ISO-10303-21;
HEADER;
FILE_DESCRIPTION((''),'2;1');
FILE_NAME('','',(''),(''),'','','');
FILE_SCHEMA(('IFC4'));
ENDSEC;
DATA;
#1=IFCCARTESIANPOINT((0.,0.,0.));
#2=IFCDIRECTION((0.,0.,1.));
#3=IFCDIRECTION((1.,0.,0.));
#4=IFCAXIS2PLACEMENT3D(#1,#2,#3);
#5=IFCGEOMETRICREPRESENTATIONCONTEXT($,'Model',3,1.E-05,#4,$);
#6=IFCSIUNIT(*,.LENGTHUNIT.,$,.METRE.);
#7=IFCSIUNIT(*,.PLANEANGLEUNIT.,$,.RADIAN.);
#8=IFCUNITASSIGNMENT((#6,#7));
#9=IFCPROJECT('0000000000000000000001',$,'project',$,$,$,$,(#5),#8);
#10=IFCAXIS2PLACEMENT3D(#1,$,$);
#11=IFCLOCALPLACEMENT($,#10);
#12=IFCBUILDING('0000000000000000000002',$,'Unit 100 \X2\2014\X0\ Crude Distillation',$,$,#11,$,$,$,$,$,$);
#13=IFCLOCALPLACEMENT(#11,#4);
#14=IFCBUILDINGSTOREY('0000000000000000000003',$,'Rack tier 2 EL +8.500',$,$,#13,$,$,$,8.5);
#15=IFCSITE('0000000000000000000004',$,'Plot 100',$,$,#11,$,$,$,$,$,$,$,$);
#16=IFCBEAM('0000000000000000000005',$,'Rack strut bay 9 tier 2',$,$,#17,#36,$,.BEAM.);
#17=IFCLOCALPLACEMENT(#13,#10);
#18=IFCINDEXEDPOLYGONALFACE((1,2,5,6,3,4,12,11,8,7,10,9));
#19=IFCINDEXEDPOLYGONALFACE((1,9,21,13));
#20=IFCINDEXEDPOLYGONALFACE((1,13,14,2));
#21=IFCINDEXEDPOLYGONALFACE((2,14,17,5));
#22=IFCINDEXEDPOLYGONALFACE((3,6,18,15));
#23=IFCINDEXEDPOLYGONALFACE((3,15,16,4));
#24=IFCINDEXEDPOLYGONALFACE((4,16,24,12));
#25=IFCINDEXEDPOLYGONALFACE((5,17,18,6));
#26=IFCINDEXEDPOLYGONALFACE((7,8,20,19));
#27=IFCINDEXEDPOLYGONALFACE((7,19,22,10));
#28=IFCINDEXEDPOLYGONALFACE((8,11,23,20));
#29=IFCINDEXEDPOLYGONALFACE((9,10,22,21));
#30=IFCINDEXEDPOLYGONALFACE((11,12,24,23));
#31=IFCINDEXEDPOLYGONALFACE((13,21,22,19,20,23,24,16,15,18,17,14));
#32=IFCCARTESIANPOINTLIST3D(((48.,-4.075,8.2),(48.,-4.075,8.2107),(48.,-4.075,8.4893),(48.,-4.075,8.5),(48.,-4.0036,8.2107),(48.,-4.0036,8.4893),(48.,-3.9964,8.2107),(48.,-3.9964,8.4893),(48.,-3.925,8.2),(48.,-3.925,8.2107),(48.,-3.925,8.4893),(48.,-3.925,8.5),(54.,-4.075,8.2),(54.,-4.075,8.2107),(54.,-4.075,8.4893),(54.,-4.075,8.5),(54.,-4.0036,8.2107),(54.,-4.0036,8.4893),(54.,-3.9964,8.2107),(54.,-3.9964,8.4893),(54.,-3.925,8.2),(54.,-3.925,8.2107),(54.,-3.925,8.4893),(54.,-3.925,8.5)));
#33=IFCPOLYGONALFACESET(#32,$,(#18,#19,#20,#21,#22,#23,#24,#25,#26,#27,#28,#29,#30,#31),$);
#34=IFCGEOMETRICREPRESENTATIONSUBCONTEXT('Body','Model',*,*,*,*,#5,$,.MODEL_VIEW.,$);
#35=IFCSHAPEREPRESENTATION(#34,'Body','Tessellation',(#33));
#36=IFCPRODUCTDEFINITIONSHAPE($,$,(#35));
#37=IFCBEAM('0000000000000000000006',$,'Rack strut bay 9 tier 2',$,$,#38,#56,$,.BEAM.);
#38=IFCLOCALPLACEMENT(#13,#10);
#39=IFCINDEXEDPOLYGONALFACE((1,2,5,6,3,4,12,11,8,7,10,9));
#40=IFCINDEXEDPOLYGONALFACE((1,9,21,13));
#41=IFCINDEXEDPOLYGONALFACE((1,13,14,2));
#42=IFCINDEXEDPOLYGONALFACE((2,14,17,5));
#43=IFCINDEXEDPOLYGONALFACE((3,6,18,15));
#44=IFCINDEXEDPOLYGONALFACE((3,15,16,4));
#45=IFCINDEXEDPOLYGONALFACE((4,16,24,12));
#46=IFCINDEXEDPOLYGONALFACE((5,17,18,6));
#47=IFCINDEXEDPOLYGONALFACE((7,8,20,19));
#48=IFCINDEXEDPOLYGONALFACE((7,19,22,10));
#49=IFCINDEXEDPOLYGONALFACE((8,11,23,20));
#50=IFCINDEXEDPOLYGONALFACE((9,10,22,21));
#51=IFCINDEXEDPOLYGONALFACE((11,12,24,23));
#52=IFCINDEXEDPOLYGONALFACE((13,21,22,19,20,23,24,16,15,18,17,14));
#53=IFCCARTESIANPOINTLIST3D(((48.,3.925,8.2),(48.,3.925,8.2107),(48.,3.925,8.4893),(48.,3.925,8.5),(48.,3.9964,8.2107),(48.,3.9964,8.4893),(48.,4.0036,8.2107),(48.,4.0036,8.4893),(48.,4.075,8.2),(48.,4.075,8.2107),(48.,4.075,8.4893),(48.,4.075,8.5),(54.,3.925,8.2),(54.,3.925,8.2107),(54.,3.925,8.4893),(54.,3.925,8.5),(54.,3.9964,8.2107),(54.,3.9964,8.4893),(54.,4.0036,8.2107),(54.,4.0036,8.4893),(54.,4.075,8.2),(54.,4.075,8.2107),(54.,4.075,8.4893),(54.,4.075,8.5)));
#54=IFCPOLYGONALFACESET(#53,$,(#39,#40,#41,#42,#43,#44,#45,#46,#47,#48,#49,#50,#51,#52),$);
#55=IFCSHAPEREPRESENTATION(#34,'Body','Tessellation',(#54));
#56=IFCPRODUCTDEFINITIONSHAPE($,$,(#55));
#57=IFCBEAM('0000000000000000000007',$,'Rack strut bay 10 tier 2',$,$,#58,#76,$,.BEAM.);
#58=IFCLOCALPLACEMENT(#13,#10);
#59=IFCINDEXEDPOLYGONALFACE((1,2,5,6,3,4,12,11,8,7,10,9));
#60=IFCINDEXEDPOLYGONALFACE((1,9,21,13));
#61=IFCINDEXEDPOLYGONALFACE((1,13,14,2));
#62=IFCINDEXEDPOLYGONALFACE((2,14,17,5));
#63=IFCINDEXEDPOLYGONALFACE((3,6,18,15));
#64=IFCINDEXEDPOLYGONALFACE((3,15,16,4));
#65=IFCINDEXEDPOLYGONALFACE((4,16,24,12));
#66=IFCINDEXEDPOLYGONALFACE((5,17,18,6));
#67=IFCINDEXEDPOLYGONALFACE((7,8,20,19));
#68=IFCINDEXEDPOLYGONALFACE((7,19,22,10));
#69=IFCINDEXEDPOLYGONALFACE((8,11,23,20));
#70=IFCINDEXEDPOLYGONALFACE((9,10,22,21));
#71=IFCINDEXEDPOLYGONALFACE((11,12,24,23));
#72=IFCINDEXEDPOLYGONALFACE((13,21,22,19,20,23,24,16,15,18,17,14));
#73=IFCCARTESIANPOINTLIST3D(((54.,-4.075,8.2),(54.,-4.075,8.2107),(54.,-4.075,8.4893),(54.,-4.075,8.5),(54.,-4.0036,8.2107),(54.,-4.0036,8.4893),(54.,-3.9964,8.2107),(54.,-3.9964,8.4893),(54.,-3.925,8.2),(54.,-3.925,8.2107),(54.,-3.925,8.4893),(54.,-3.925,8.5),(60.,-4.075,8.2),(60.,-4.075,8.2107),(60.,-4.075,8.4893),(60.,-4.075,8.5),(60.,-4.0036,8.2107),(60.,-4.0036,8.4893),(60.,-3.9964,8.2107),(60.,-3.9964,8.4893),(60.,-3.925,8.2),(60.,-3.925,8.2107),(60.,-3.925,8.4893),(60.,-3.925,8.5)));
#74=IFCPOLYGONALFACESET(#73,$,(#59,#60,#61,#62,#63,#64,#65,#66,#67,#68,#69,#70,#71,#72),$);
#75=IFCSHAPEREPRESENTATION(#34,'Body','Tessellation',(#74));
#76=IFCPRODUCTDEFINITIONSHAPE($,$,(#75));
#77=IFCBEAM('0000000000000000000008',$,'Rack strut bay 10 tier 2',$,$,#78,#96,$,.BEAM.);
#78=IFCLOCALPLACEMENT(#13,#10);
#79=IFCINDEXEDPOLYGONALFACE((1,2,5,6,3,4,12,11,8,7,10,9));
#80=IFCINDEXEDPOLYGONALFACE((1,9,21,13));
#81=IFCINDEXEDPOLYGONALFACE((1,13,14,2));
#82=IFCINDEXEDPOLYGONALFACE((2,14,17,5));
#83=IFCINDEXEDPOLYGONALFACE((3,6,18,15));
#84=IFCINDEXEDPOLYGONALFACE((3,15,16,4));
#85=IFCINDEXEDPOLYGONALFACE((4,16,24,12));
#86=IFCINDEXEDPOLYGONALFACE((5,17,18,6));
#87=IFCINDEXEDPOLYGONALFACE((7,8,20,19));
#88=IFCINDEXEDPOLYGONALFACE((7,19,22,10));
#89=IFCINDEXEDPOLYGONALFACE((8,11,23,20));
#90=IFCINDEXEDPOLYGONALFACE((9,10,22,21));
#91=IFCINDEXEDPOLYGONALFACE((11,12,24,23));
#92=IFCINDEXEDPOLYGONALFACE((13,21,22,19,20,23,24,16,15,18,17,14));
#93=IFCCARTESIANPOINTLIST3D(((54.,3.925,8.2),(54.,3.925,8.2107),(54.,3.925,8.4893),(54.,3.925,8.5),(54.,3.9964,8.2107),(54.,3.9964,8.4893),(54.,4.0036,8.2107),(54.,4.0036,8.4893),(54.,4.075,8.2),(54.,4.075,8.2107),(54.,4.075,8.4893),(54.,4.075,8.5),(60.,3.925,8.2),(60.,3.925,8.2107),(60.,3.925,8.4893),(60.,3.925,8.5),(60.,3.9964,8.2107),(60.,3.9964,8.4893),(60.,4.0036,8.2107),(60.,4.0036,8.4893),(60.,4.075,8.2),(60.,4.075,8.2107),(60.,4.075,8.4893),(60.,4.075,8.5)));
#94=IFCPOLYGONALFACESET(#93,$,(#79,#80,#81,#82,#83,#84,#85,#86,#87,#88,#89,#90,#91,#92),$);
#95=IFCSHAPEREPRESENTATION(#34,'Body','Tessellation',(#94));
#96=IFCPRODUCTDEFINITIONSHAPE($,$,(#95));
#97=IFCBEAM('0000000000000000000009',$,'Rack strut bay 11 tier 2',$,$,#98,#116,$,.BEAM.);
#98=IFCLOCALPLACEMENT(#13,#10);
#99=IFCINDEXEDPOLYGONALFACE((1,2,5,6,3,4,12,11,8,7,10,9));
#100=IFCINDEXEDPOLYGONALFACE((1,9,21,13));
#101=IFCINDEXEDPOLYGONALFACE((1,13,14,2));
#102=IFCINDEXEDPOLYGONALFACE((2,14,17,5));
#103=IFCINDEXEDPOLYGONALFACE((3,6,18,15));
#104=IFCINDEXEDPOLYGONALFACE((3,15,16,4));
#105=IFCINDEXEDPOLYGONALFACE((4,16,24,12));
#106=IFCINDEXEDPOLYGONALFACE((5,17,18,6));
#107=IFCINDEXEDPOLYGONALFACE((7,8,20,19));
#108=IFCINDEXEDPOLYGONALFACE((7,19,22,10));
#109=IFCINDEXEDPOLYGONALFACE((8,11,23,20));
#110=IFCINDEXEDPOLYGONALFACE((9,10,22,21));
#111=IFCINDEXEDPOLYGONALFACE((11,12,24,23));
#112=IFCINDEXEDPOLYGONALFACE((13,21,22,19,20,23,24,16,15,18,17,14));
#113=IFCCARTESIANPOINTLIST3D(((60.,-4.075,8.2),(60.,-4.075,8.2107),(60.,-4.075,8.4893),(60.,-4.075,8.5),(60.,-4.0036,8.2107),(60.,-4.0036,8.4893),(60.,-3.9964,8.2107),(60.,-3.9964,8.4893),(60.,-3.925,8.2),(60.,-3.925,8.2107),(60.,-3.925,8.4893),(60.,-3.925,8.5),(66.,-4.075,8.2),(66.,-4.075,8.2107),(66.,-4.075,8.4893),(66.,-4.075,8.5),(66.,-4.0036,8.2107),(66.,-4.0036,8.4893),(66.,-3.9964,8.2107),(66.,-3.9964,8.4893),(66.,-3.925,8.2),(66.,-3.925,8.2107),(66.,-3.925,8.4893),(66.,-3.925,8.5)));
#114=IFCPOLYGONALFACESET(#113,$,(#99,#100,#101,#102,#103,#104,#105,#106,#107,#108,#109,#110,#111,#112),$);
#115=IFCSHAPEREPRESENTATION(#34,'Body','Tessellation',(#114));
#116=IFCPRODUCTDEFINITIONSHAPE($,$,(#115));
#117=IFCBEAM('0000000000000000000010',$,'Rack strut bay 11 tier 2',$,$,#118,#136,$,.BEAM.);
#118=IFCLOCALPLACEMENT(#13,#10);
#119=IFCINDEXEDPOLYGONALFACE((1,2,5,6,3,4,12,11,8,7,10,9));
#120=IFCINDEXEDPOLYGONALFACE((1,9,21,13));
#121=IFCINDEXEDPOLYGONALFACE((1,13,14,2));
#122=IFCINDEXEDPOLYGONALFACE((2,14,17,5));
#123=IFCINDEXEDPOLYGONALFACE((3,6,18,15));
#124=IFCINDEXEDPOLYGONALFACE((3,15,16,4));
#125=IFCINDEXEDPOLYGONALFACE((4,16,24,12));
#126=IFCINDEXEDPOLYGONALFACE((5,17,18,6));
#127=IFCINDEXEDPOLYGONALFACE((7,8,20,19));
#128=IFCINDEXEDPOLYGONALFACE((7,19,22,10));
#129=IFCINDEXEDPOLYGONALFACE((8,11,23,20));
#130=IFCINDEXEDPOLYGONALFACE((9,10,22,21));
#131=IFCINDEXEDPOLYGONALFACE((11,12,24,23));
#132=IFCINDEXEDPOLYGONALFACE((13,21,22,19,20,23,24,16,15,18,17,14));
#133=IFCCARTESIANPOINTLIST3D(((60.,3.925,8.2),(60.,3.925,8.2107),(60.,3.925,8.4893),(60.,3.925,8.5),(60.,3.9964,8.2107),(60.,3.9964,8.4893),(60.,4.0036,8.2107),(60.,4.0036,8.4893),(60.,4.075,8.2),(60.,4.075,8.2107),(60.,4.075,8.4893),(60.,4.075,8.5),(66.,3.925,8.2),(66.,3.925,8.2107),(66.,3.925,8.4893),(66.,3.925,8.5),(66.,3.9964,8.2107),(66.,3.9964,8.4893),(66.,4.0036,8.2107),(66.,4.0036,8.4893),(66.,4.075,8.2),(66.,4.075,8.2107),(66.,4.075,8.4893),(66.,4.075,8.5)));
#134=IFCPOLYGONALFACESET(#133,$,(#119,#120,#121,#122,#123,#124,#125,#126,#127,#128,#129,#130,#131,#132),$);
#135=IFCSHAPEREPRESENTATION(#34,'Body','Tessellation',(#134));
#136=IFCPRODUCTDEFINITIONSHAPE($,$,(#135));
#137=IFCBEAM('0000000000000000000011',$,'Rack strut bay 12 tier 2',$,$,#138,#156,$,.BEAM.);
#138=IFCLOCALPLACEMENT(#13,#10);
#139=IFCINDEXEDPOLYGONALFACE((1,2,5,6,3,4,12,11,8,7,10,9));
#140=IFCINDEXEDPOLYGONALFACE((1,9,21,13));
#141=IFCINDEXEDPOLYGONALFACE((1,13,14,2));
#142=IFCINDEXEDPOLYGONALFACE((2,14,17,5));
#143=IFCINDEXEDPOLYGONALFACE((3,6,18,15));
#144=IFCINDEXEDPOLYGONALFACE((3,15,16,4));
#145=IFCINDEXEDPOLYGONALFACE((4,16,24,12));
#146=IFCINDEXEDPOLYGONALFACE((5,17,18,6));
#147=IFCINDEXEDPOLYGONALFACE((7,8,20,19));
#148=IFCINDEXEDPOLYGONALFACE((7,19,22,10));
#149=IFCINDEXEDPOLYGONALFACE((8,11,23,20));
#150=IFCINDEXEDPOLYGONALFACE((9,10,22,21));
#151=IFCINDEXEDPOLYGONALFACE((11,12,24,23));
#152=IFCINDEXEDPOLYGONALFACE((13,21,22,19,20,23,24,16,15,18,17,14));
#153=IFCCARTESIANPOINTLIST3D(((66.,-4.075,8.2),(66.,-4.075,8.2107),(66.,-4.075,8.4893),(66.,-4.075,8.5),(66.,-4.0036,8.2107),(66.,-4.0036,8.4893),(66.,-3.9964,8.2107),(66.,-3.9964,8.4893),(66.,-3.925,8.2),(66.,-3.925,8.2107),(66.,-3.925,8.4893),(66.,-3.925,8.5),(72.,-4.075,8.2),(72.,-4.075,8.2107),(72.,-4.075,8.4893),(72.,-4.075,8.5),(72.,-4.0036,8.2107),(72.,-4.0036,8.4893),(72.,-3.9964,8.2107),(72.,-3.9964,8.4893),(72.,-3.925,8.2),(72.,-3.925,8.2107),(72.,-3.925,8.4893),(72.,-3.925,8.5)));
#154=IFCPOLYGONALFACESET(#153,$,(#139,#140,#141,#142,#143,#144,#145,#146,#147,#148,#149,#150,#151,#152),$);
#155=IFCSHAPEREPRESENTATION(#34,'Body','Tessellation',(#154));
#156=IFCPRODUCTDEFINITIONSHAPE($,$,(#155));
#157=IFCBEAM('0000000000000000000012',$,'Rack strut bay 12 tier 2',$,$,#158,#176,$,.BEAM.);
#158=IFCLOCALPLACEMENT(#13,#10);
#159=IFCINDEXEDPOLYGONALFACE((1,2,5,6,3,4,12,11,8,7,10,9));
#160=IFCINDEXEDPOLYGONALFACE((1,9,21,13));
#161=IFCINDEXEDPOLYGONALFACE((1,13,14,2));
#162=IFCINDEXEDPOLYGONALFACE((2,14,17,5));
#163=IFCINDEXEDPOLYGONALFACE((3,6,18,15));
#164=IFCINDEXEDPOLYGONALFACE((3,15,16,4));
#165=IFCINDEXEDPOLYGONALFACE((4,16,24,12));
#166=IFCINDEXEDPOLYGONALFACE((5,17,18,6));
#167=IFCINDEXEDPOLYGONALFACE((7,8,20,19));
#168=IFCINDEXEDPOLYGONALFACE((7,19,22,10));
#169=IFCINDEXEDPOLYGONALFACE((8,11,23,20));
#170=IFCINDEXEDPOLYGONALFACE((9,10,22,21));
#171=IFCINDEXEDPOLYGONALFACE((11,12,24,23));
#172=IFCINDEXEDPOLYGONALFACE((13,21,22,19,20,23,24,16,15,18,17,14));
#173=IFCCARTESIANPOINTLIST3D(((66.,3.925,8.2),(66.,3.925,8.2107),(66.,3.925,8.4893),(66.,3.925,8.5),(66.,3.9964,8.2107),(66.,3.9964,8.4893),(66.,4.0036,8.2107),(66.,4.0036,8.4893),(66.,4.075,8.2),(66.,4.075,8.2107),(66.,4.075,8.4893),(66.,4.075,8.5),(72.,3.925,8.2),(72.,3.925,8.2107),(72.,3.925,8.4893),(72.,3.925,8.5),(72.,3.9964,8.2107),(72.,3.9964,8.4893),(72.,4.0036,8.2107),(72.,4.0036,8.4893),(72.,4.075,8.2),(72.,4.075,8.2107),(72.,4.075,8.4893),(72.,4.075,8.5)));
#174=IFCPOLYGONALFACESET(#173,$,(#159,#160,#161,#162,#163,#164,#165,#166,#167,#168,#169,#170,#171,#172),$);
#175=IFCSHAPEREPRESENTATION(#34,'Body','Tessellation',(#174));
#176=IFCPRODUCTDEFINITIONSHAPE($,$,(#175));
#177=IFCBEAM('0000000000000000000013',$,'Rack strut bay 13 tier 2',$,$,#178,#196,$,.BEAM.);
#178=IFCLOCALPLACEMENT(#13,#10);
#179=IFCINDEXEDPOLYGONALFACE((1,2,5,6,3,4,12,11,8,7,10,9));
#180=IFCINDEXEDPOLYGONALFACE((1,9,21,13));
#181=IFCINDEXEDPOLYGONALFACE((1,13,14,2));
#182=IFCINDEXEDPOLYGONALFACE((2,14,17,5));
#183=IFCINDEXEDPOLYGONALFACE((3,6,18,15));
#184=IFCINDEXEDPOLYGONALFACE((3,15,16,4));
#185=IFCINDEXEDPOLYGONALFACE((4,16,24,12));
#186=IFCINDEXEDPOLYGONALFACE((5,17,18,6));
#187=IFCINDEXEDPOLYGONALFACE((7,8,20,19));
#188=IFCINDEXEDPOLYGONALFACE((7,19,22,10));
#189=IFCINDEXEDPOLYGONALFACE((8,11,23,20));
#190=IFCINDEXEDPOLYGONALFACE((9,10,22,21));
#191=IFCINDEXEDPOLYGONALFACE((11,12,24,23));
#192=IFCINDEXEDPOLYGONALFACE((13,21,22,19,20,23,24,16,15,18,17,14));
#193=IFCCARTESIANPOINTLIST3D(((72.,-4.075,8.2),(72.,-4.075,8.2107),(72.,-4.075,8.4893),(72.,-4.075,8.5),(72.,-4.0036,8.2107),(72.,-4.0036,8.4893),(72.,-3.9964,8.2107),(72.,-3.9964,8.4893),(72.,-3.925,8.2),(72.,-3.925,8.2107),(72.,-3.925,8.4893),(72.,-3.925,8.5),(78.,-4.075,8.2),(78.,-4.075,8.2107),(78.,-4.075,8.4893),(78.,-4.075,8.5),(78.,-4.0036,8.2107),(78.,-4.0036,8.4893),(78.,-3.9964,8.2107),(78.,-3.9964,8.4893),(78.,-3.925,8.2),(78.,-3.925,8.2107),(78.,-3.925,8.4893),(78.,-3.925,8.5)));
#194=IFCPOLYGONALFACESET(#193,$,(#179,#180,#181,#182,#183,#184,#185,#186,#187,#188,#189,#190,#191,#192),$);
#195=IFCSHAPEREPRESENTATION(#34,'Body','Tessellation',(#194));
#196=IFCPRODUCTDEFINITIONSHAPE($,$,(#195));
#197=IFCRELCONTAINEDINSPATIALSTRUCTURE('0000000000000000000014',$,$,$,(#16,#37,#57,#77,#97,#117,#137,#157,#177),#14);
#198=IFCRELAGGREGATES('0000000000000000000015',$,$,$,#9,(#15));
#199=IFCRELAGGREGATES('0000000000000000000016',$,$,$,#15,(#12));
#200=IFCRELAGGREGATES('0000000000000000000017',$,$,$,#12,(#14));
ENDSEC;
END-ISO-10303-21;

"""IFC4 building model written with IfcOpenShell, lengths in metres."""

from ifc_helpers import new_model, si_unit, frame, origin, origin_with_axes, origin_2d, place, context, subcontext, project, spatial, i_section, extrude, element, save


model = new_model("IFC4")

# Units and contexts
model_context = context("Model", 3, precision=1e-05, world=origin_with_axes())
body_context = subcontext(model_context, "Body", "Model", "MODEL_VIEW")
ifc_project = project(units=[si_unit("LENGTHUNIT", "METRE"), si_unit("PLANEANGLEUNIT", "RADIAN")], contexts=[model_context])

# Site, building, storey
placement = place(None, origin())
site = spatial("IfcSite", under=ifc_project, at=placement, Name="Plot 100")
building = spatial("IfcBuilding", under=site, at=placement, Name="Unit 100 — Crude Distillation")
storey_placement = place(placement, origin_with_axes())
storey = spatial("IfcBuildingStorey", under=building, at=storey_placement, Name="Rack tier 2 EL +8.500", Elevation=8.5)

# Beams
beam_1_placement = place(storey_placement, origin_with_axes())
element("IfcBeam", 1, at=beam_1_placement, inside=storey, Name="Rack strut bay 9 tier 2", PredefinedType="BEAM", context=body_context, shape_type="SweptSolid", body=[
    extrude(i_section(OverallWidth=0.15, OverallDepth=0.3, WebThickness=0.0071, FlangeThickness=0.0107, at=origin_2d()), frame((48.0, -4.0, 8.35), z_axis=(1.0, 0.0, 0.0), x_axis=(0.0, 1.0, 0.0)), (0.0, 0.0, 1.0), 6.0),
])
beam_2_placement = place(storey_placement, origin_with_axes())
element("IfcBeam", 2, at=beam_2_placement, inside=storey, Name="Rack strut bay 9 tier 2", PredefinedType="BEAM", context=body_context, shape_type="SweptSolid", body=[
    extrude(i_section(OverallWidth=0.15, OverallDepth=0.3, WebThickness=0.0071, FlangeThickness=0.0107, at=origin_2d()), frame((48.0, 4.0, 8.35), z_axis=(1.0, 0.0, 0.0), x_axis=(0.0, 1.0, 0.0)), (0.0, 0.0, 1.0), 6.0),
])
beam_3_placement = place(storey_placement, origin_with_axes())
element("IfcBeam", 3, at=beam_3_placement, inside=storey, Name="Rack strut bay 10 tier 2", PredefinedType="BEAM", context=body_context, shape_type="SweptSolid", body=[
    extrude(i_section(OverallWidth=0.15, OverallDepth=0.3, WebThickness=0.0071, FlangeThickness=0.0107, at=origin_2d()), frame((54.0, -4.0, 8.35), z_axis=(1.0, 0.0, 0.0), x_axis=(0.0, 1.0, 0.0)), (0.0, 0.0, 1.0), 6.0),
])
beam_4_placement = place(storey_placement, origin_with_axes())
element("IfcBeam", 4, at=beam_4_placement, inside=storey, Name="Rack strut bay 10 tier 2", PredefinedType="BEAM", context=body_context, shape_type="SweptSolid", body=[
    extrude(i_section(OverallWidth=0.15, OverallDepth=0.3, WebThickness=0.0071, FlangeThickness=0.0107, at=origin_2d()), frame((54.0, 4.0, 8.35), z_axis=(1.0, 0.0, 0.0), x_axis=(0.0, 1.0, 0.0)), (0.0, 0.0, 1.0), 6.0),
])
beam_5_placement = place(storey_placement, origin_with_axes())
element("IfcBeam", 5, at=beam_5_placement, inside=storey, Name="Rack strut bay 11 tier 2", PredefinedType="BEAM", context=body_context, shape_type="SweptSolid", body=[
    extrude(i_section(OverallWidth=0.15, OverallDepth=0.3, WebThickness=0.0071, FlangeThickness=0.0107, at=origin_2d()), frame((60.0, -4.0, 8.35), z_axis=(1.0, 0.0, 0.0), x_axis=(0.0, 1.0, 0.0)), (0.0, 0.0, 1.0), 6.0),
])
beam_6_placement = place(storey_placement, origin_with_axes())
element("IfcBeam", 6, at=beam_6_placement, inside=storey, Name="Rack strut bay 11 tier 2", PredefinedType="BEAM", context=body_context, shape_type="SweptSolid", body=[
    extrude(i_section(OverallWidth=0.15, OverallDepth=0.3, WebThickness=0.0071, FlangeThickness=0.0107, at=origin_2d()), frame((60.0, 4.0, 8.35), z_axis=(1.0, 0.0, 0.0), x_axis=(0.0, 1.0, 0.0)), (0.0, 0.0, 1.0), 6.0),
])
beam_7_placement = place(storey_placement, origin_with_axes())
element("IfcBeam", 7, at=beam_7_placement, inside=storey, Name="Rack strut bay 12 tier 2", PredefinedType="BEAM", context=body_context, shape_type="SweptSolid", body=[
    extrude(i_section(OverallWidth=0.15, OverallDepth=0.3, WebThickness=0.0071, FlangeThickness=0.0107, at=origin_2d()), frame((66.0, -4.0, 8.35), z_axis=(1.0, 0.0, 0.0), x_axis=(0.0, 1.0, 0.0)), (0.0, 0.0, 1.0), 6.0),
])
beam_8_placement = place(storey_placement, origin_with_axes())
element("IfcBeam", 8, at=beam_8_placement, inside=storey, Name="Rack strut bay 12 tier 2", PredefinedType="BEAM", context=body_context, shape_type="SweptSolid", body=[
    extrude(i_section(OverallWidth=0.15, OverallDepth=0.3, WebThickness=0.0071, FlangeThickness=0.0107, at=origin_2d()), frame((66.0, 4.0, 8.35), z_axis=(1.0, 0.0, 0.0), x_axis=(0.0, 1.0, 0.0)), (0.0, 0.0, 1.0), 6.0),
])
beam_9_placement = place(storey_placement, origin_with_axes())
element("IfcBeam", 9, at=beam_9_placement, inside=storey, Name="Rack strut bay 13 tier 2", PredefinedType="BEAM", context=body_context, shape_type="SweptSolid", body=[
    extrude(i_section(OverallWidth=0.15, OverallDepth=0.3, WebThickness=0.0071, FlangeThickness=0.0107, at=origin_2d()), frame((72.0, -4.0, 8.35), z_axis=(1.0, 0.0, 0.0), x_axis=(0.0, 1.0, 0.0)), (0.0, 0.0, 1.0), 6.0),
])

save(model, "model.ifc")
